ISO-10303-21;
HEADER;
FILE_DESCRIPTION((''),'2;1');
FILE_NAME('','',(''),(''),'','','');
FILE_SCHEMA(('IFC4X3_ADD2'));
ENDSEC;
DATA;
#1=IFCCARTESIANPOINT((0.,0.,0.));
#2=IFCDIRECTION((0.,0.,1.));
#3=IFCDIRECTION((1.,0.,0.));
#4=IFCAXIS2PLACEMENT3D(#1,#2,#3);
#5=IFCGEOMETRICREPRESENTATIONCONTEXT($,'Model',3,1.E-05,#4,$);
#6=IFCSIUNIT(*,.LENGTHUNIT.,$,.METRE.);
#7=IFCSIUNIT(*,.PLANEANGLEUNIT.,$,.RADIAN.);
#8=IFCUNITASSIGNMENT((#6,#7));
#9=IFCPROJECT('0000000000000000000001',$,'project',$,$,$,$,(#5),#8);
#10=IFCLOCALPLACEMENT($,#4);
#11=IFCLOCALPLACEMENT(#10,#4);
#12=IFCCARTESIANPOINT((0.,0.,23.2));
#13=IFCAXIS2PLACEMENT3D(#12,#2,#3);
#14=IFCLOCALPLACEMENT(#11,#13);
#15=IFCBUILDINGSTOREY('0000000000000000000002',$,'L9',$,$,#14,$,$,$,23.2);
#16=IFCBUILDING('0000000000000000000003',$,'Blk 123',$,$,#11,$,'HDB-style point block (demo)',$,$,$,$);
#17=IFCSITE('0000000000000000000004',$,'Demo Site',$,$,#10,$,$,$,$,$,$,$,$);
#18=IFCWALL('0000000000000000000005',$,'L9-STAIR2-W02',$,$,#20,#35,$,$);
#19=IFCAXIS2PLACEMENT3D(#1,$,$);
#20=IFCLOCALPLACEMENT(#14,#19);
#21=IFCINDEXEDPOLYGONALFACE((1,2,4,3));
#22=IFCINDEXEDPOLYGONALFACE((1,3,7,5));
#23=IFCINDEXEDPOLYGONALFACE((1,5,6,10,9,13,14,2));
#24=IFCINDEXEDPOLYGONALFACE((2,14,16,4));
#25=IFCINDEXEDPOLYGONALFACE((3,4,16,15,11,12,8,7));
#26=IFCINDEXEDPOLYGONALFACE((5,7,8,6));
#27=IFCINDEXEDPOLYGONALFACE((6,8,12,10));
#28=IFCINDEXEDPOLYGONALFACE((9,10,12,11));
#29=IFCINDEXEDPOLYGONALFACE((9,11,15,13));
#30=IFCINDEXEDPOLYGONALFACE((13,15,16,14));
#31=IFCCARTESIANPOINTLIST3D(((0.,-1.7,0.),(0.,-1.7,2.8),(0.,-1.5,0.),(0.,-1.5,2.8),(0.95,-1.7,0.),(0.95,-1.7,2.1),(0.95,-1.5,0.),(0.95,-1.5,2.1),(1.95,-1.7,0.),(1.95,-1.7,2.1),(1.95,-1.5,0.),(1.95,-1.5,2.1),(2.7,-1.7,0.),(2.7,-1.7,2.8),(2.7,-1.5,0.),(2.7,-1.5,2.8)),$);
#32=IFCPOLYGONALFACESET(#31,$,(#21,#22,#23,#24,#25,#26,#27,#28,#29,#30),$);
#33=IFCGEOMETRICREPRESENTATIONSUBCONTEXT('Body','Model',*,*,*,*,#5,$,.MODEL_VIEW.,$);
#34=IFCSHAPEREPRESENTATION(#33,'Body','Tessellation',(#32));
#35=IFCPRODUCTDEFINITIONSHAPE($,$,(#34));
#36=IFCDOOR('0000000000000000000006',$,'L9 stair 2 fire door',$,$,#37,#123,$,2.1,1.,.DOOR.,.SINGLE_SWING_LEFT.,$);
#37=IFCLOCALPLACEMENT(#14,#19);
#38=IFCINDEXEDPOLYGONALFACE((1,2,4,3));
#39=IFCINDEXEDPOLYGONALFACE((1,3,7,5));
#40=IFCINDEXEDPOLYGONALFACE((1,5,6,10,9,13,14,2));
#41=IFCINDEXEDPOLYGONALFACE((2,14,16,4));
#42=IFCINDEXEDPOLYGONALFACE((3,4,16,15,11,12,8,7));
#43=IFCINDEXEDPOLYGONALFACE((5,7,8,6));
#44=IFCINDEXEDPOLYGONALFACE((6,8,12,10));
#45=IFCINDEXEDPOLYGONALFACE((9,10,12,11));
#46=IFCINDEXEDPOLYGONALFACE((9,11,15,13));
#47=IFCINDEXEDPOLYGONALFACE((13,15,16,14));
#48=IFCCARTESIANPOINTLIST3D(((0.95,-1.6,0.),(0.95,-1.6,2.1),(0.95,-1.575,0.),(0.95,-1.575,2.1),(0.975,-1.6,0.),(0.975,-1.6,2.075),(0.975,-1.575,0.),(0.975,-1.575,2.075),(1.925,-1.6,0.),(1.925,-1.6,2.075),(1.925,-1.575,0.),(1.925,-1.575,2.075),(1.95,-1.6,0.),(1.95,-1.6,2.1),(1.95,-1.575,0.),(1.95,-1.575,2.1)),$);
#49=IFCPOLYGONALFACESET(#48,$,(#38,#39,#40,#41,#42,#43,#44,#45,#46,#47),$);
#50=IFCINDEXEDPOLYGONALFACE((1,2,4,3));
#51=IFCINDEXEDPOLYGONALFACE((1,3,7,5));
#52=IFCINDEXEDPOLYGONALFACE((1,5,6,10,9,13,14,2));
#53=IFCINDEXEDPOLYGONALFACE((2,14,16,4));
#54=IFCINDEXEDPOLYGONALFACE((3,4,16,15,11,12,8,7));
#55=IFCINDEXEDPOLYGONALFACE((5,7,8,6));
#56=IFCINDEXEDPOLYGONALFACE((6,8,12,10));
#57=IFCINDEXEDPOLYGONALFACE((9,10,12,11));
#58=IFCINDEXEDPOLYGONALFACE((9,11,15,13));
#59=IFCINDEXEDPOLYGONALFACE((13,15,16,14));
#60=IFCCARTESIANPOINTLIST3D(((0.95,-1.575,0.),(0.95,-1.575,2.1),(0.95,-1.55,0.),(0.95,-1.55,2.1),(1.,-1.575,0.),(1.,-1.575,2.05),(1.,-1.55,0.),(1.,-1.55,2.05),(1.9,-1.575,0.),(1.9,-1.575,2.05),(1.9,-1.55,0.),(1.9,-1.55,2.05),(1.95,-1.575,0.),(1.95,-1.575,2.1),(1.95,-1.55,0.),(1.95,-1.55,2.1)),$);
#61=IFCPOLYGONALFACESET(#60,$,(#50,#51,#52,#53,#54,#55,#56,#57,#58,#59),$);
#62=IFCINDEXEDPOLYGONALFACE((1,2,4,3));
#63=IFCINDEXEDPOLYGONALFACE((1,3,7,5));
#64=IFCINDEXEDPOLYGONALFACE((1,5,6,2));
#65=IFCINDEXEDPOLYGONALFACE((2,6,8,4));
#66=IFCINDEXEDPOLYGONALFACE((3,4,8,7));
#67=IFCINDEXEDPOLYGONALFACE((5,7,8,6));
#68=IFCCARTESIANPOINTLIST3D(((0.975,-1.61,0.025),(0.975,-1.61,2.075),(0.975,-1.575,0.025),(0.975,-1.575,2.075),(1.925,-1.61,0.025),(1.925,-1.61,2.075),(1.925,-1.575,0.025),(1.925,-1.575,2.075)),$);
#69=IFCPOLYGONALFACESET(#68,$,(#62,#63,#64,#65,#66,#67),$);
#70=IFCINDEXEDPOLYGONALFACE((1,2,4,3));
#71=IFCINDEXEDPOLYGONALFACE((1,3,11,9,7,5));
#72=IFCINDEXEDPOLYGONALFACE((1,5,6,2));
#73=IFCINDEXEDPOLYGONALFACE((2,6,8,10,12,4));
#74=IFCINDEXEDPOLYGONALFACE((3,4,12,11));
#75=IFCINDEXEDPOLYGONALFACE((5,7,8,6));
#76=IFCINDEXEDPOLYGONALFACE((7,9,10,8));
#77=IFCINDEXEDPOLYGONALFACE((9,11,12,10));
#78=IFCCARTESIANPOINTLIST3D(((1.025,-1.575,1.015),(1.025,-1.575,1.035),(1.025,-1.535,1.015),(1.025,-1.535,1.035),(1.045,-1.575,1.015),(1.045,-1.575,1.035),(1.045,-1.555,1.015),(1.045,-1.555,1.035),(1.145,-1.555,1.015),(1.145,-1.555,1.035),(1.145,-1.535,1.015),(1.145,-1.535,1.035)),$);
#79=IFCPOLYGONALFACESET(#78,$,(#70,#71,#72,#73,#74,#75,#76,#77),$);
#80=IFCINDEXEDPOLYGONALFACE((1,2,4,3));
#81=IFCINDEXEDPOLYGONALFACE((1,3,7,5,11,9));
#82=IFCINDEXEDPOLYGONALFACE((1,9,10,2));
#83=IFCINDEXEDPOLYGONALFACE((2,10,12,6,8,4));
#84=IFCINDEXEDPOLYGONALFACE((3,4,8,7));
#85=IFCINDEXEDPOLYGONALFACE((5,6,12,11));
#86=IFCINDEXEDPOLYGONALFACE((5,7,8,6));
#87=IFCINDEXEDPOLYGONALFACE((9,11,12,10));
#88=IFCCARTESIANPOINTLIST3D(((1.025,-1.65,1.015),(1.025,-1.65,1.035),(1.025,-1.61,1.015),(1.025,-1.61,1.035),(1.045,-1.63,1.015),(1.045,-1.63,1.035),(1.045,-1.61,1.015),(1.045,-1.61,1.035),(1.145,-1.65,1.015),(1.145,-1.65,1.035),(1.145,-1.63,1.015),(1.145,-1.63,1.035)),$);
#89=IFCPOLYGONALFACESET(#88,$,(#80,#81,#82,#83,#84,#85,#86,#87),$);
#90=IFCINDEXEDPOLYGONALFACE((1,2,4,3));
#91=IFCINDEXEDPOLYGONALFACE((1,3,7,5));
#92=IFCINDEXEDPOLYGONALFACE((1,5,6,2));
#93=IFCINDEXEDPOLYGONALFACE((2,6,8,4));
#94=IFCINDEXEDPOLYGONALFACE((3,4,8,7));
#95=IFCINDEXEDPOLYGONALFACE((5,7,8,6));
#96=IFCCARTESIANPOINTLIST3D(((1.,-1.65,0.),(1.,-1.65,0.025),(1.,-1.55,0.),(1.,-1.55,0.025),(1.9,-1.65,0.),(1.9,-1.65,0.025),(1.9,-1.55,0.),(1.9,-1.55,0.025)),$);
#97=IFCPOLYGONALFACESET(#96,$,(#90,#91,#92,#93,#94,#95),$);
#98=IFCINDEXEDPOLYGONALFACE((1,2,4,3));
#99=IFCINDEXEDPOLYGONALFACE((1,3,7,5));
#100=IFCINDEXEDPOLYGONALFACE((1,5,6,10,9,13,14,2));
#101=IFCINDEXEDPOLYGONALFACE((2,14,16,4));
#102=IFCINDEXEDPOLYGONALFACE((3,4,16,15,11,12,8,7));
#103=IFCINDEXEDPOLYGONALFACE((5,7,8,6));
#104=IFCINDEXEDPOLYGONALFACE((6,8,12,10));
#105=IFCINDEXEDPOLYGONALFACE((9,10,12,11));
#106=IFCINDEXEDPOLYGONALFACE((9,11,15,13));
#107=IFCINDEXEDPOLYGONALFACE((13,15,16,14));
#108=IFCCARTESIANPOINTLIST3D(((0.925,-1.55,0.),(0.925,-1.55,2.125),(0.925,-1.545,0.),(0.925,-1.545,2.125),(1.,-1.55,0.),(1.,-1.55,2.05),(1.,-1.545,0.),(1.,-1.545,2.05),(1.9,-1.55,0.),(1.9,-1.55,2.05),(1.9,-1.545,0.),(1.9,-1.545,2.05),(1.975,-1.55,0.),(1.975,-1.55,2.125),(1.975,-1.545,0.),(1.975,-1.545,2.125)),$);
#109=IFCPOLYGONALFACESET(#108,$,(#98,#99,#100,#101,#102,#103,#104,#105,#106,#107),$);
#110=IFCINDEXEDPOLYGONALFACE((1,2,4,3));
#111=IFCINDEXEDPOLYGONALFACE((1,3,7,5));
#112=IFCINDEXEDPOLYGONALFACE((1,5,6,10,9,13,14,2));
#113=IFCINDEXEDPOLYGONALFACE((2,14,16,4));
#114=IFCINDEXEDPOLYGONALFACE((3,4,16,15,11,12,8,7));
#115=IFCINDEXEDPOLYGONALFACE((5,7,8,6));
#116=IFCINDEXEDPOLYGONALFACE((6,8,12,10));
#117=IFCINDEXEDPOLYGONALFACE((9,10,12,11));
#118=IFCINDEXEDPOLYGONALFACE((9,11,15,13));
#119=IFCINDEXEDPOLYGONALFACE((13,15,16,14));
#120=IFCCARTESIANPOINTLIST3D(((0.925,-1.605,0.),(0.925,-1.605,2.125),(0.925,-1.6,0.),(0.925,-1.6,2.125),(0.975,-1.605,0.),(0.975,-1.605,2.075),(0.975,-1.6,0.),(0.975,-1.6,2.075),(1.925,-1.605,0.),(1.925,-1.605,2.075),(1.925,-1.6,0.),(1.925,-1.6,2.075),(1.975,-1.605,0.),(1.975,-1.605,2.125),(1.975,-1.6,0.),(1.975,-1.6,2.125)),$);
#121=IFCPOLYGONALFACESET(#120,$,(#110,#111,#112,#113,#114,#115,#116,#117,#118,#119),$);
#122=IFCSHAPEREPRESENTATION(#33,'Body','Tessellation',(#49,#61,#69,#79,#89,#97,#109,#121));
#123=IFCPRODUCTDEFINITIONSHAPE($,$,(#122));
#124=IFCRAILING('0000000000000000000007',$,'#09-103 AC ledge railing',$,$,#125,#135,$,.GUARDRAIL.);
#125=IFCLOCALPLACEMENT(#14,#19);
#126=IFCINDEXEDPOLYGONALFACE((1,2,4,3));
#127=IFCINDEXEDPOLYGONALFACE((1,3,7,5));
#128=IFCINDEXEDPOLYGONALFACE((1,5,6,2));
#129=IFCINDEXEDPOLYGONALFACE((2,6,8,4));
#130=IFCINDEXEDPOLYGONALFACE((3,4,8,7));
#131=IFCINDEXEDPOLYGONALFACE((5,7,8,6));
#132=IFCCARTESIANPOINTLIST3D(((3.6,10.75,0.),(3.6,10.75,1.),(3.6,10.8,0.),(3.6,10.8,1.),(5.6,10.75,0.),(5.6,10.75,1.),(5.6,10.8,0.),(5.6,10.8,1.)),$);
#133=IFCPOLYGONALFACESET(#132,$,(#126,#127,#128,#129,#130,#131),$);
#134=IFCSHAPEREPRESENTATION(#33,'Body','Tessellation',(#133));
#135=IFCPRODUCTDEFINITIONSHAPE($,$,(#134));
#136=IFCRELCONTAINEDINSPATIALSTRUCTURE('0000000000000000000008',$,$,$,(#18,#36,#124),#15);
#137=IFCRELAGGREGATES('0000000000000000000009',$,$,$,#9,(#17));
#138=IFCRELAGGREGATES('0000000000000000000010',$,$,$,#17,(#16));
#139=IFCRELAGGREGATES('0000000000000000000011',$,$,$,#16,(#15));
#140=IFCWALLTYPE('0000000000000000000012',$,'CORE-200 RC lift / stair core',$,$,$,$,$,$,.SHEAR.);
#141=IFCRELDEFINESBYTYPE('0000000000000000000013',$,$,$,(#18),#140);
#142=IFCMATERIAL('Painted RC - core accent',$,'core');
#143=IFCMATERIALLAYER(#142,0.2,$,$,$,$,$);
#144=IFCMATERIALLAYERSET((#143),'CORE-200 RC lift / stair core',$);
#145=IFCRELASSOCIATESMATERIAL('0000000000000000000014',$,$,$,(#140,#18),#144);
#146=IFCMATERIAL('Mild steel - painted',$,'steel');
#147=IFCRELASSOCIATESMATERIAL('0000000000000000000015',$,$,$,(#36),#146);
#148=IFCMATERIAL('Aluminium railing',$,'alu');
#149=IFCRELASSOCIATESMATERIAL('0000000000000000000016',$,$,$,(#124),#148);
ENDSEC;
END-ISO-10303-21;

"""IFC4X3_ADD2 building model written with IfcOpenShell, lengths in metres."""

from ifc_helpers import new_model, si_unit, frame, origin, origin_with_axes, place, context, subcontext, project, spatial, polyline, line, indexed_curve, outline, extrude, material, layer, layer_set, layer_usage, type_object, element, fill, save


model = new_model("IFC4X3_ADD2")

# Units and contexts
model_context = context("Model", 3, precision=1e-05, world=origin_with_axes())
body_context = subcontext(model_context, "Body", "Model", "MODEL_VIEW")
ifc_project = project(units=[si_unit("LENGTHUNIT", "METRE"), si_unit("PLANEANGLEUNIT", "RADIAN")], contexts=[model_context])

# Site, building, storey
site_placement = place(None, origin_with_axes())
site = spatial("IfcSite", under=ifc_project, at=site_placement, Name="Demo Site")
building_placement = place(site_placement, origin_with_axes())
building = spatial("IfcBuilding", under=site, at=building_placement, Name="Blk 123", LongName="HDB-style point block (demo)")
storey_placement = place(building_placement, frame((0.0, 0.0, 23.2), z_axis=(0.0, 0.0, 1.0), x_axis=(1.0, 0.0, 0.0)))
storey = spatial("IfcBuildingStorey", under=building, at=storey_placement, Name="L9", Elevation=23.2)

# Shared definitions
ifc_material_1 = material(Name="Painted RC - core accent", Category="core")
ifc_layer_1 = layer(ifc_material_1, 0.2)
ifc_layer_set_1 = layer_set([ifc_layer_1], Name="CORE-200 RC lift / stair core")
ifc_layer_usage_1 = layer_usage(ifc_layer_set_1, "AXIS2", "POSITIVE", 0.0)
wall_type_1 = type_object("IfcWallType", Name="CORE-200 RC lift / stair core", PredefinedType="SHEAR", material=ifc_layer_set_1)

# Wall, opening, door
wall_1_placement = place(storey_placement, frame((2.7, -1.5, 0.0), z_axis=(0.0, 0.0, 1.0), x_axis=(-1.0, 0.0, 0.0)))
wall_1 = element("IfcWall", 1, at=wall_1_placement, inside=storey, type_object=wall_type_1, material=ifc_layer_usage_1, Name="L9-STAIR2-W02", context=body_context, shape_type="SweptSolid", body=[
    extrude(outline(indexed_curve([(0.0, 0.0), (0.0, 0.2), (2.7, 0.2), (2.7, 0.0), (0.0, 0.0)], self_intersect=False)), origin_with_axes(), (0.0, 0.0, 1.0), 2.8),
])
opening_1_placement = place(wall_1_placement, frame((0.75, -0.1, 0.0), z_axis=(0.0, 0.0, 1.0), x_axis=(1.0, 0.0, 0.0)))
opening_1 = element("IfcOpeningElement", 2, at=opening_1_placement, cuts=wall_1, context=body_context, shape_type="SweptSolid", body=[
    extrude(outline(indexed_curve([(0.0, 0.0), (0.0, 0.4), (1.0, 0.4), (1.0, 0.0), (0.0, 0.0)], self_intersect=False)), origin_with_axes(), (0.0, 0.0, 1.0), 2.1),
])
ifc_material_2 = material(Name="Mild steel - painted", Category="steel")
door_1_placement = place(opening_1_placement, frame((0.0, 0.15, 0.0), z_axis=(0.0, 0.0, 1.0), x_axis=(1.0, 0.0, 0.0)))
door_1 = element("IfcDoor", 3, at=door_1_placement, inside=storey, material=ifc_material_2, Name="L9 stair 2 fire door", OperationType="SINGLE_SWING_LEFT", OverallHeight=2.1, OverallWidth=1.0, PredefinedType="DOOR", context=body_context, shape_type="SweptSolid", body=[
    extrude(outline(indexed_curve([(0.0, 0.0), (0.0, 2.1), (1.0, 2.1), (1.0, 0.0), (0.975, 0.0), (0.975, 2.075), (0.025, 2.075), (0.025, 0.0)], segments=[line(1, 2, 3, 4, 5, 6, 7, 8, 1)])), frame((0.0, 0.025, 0.0), z_axis=(0.0, -1.0, 0.0), x_axis=(1.0, 0.0, 0.0)), (0.0, 0.0, -1.0), 0.025),
    extrude(outline(indexed_curve([(0.0, 0.0), (0.0, 2.1), (1.0, 2.1), (1.0, 0.0), (0.95, 0.0), (0.95, 2.05), (0.05, 2.05), (0.05, 0.0)], segments=[line(1, 2, 3, 4, 5, 6, 7, 8, 1)])), frame((0.0, 0.0, 0.0), z_axis=(0.0, -1.0, 0.0), x_axis=(1.0, 0.0, 0.0)), (0.0, 0.0, -1.0), 0.025),
    extrude(outline(indexed_curve([(0.0, 0.0), (0.95, 0.0), (0.95, 0.035), (0.0, 0.035)], segments=[line(1, 2, 3, 4, 1)])), frame((0.025, 0.025, 0.025), z_axis=(0.0, 0.0, 1.0), x_axis=(1.0, 0.0, 0.0)), (0.0, 0.0, 1.0), 2.05),
    extrude(outline(indexed_curve([(0.0, 0.0), (0.0, -0.04), (-0.12, -0.04), (-0.12, -0.02), (-0.02, -0.02), (-0.02, 0.0)], segments=[line(1, 2, 3, 4, 5, 6, 1)])), frame((0.925, 0.025, 1.015), z_axis=(0.0, 0.0, 1.0), x_axis=(1.0, 0.0, 0.0)), (0.0, 0.0, 1.0), 0.02),
    extrude(outline(indexed_curve([(0.0, 0.0), (0.0, 0.04), (-0.12, 0.04), (-0.12, 0.02), (-0.02, 0.02), (-0.02, 0.0)], segments=[line(1, 2, 3, 4, 5, 6, 1)])), frame((0.925, 0.06, 1.015), z_axis=(0.0, 0.0, 1.0), x_axis=(1.0, 0.0, 0.0)), (0.0, 0.0, 1.0), 0.02),
    extrude(outline(indexed_curve([(0.0, 0.0), (0.9, 0.0), (0.9, 0.1), (0.0, 0.1)], segments=[line(1, 2, 3, 4, 1)])), frame((0.05, 0.0, 0.0), z_axis=(0.0, 0.0, 1.0), x_axis=(1.0, 0.0, 0.0)), (0.0, 0.0, 1.0), 0.025),
    extrude(outline(indexed_curve([(0.0, 0.0), (0.0, 2.125), (1.05, 2.125), (1.05, 0.0), (0.975, 0.0), (0.975, 2.05), (0.075, 2.05), (0.075, 0.0)], segments=[line(1, 2, 3, 4, 5, 6, 7, 8, 1)])), frame((-0.025, -0.005, 0.0), z_axis=(0.0, -1.0, 0.0), x_axis=(1.0, 0.0, 0.0)), (0.0, 0.0, -1.0), 0.005),
    extrude(outline(indexed_curve([(0.0, 0.0), (0.0, 2.125), (1.05, 2.125), (1.05, 0.0), (1.0, 0.0), (1.0, 2.075), (0.05, 2.075), (0.05, 0.0)], segments=[line(1, 2, 3, 4, 5, 6, 7, 8, 1)])), frame((-0.025, 0.05, 0.0), z_axis=(0.0, -1.0, 0.0), x_axis=(1.0, 0.0, 0.0)), (0.0, 0.0, -1.0), 0.005),
])
fill(opening_1, door_1)

# Railing
ifc_material_3 = material(Name="Aluminium railing", Category="alu")
railing_placement = place(storey_placement, frame((4.6, 10.775, 0.0), z_axis=(0.0, 0.0, 1.0), x_axis=(1.0, 0.0, 0.0)))
element("IfcRailing", 4, at=railing_placement, inside=storey, material=ifc_material_3, Name="#09-103 AC ledge railing", PredefinedType="GUARDRAIL", context=body_context, shape_type="SweptSolid", body=[
    extrude(outline(polyline([(1.0, -0.025), (1.0, 0.025), (-1.0, 0.025), (-1.0, -0.025), (1.0, -0.025)])), origin(), (0.0, 0.0, 1.0), 1.0),
])

save(model, "model.ifc")
